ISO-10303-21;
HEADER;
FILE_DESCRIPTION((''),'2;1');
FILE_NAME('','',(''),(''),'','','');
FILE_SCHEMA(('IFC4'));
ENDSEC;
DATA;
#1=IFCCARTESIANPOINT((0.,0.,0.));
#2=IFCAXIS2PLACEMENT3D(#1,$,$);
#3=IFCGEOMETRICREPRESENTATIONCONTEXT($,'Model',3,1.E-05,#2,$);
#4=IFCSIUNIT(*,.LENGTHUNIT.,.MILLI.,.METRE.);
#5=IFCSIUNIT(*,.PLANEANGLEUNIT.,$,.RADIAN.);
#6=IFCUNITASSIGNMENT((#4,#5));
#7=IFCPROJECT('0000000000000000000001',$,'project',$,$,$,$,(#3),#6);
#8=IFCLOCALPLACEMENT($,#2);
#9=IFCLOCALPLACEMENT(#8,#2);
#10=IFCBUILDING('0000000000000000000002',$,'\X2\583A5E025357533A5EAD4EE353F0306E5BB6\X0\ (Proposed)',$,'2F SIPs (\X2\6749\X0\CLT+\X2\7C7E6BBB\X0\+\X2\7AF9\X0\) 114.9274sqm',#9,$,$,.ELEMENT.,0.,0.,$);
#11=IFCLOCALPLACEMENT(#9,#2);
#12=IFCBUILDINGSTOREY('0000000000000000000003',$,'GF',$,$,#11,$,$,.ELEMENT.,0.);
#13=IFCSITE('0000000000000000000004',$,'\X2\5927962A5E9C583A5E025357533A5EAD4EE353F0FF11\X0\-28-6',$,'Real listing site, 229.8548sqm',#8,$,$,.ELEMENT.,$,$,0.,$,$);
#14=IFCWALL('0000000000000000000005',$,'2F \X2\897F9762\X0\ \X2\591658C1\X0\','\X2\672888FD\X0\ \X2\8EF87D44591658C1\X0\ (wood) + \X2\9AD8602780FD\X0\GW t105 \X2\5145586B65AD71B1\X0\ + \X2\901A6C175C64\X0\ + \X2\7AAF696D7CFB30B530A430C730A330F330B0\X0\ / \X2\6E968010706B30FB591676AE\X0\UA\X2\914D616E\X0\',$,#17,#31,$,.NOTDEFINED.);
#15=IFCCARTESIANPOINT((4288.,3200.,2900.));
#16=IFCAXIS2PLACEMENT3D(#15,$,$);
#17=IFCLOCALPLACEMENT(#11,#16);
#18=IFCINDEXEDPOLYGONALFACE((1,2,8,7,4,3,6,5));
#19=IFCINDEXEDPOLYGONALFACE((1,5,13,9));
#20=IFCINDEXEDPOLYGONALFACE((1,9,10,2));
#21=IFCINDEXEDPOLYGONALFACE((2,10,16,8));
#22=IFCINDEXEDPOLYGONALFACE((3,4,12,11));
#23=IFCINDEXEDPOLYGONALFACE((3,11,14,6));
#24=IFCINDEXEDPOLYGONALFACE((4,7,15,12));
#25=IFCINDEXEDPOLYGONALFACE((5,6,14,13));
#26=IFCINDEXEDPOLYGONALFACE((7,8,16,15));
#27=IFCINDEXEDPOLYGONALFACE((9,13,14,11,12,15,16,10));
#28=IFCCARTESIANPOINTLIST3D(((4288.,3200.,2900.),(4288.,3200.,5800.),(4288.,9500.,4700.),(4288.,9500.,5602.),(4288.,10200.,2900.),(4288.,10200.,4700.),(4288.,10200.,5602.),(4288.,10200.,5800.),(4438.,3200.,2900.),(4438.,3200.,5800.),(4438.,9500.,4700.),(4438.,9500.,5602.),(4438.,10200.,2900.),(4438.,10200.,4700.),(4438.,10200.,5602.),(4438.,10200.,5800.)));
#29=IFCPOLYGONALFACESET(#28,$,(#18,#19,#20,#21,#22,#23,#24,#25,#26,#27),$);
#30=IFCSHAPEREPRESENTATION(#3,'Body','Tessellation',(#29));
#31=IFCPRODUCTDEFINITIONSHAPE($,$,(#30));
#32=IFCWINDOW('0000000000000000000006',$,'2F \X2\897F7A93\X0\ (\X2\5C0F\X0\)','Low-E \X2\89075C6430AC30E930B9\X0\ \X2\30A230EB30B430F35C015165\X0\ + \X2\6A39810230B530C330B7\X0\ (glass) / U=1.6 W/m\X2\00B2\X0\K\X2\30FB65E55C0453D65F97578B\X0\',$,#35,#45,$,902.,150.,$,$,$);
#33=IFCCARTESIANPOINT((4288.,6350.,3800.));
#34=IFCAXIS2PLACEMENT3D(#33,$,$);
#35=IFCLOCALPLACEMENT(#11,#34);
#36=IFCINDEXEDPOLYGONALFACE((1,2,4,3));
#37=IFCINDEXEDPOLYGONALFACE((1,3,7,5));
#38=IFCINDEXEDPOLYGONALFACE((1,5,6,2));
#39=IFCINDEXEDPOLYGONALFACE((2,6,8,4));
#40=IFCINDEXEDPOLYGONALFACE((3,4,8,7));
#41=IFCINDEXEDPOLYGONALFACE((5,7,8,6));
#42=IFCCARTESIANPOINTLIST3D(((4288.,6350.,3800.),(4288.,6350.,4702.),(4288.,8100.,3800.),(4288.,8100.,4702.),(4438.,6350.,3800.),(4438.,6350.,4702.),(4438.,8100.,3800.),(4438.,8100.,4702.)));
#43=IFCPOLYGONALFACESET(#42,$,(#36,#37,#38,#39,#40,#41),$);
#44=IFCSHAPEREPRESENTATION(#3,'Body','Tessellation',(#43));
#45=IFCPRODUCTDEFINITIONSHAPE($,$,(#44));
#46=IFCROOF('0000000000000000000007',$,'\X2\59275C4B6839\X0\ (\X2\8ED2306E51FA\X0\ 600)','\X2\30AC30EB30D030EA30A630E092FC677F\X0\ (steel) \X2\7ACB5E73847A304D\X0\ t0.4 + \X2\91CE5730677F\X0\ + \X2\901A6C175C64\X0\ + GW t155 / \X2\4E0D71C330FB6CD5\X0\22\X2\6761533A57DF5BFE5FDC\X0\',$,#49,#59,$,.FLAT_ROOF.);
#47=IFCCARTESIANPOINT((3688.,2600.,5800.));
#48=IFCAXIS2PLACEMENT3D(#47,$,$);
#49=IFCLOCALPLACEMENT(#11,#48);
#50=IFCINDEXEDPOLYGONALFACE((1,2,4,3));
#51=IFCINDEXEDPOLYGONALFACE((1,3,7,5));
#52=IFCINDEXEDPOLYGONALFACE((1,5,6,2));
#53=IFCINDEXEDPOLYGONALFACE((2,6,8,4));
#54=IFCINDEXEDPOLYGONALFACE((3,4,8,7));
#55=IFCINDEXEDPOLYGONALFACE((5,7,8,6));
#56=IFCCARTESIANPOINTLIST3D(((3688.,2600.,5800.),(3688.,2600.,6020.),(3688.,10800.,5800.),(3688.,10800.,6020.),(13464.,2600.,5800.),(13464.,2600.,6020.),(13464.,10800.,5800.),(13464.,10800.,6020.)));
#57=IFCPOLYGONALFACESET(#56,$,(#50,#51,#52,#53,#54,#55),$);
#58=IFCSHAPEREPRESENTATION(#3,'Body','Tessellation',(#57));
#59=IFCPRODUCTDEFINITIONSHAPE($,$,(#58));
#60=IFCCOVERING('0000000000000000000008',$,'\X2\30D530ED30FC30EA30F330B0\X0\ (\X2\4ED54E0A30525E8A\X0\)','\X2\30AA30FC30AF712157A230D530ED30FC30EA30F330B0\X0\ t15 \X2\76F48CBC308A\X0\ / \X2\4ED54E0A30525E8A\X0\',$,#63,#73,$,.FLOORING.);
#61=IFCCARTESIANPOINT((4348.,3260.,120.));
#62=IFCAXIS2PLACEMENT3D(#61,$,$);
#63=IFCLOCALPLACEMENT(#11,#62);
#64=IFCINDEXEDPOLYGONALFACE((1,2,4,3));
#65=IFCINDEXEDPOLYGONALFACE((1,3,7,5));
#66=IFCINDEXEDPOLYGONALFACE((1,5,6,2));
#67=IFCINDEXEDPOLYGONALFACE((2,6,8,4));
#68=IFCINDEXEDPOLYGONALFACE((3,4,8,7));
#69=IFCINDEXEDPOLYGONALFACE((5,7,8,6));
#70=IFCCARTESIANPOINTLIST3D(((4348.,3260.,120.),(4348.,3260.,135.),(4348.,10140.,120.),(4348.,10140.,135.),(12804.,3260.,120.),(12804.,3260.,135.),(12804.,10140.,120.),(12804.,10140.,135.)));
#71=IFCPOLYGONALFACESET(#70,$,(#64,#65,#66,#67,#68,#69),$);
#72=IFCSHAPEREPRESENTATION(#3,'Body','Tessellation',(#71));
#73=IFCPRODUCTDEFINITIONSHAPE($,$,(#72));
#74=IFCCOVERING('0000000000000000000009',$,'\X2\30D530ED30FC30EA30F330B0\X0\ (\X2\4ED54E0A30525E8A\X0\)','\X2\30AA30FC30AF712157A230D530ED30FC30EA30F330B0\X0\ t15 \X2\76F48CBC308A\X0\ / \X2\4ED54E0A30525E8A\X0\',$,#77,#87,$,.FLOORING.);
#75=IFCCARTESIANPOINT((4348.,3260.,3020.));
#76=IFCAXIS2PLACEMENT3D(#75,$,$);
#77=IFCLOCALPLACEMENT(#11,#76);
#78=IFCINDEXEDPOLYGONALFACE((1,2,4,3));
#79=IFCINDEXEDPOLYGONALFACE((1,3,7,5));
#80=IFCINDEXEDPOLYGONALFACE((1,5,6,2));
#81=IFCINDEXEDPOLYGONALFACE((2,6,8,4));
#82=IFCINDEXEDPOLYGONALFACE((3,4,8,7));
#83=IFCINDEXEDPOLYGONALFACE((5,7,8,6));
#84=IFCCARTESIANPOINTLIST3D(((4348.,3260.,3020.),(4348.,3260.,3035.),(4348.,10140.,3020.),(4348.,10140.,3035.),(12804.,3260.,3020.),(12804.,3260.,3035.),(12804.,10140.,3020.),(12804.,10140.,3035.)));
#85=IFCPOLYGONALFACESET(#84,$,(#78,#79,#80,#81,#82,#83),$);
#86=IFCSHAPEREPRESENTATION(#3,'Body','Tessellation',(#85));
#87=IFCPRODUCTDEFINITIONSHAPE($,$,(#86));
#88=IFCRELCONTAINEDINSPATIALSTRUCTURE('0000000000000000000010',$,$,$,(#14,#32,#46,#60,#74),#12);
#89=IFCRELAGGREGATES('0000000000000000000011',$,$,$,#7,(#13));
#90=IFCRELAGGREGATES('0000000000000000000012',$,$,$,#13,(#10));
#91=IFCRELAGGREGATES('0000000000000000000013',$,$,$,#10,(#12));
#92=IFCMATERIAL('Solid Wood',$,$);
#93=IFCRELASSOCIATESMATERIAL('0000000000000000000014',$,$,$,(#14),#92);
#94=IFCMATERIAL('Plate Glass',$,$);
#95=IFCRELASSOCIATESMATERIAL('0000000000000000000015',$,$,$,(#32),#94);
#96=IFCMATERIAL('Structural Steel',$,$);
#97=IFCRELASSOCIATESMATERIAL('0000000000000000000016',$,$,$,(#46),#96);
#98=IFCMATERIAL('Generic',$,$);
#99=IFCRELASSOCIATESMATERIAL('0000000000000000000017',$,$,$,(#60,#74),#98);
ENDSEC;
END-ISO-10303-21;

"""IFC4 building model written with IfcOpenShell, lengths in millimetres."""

from ifc_helpers import new_model, si_unit, frame, frame_2d, origin, place, context, project, spatial, rectangle, extrude, material, element, fill, save


model = new_model("IFC4")

# Units and contexts
model_context = context("Model", 3, precision=1e-05, world=origin())
ifc_project = project(units=[si_unit("LENGTHUNIT", "METRE", prefix="MILLI"), si_unit("PLANEANGLEUNIT", "RADIAN")], contexts=[model_context])

# Site, building, storey
site_placement = place(None, origin())
site = spatial("IfcSite", under=ifc_project, at=site_placement, Name="大阪府堺市南区庭代台１-28-6", ObjectType="Real listing site, 229.8548sqm", CompositionType="ELEMENT", RefElevation=0.0)
building_placement = place(site_placement, origin())
building = spatial("IfcBuilding", under=site, at=building_placement, Name="堺市南区庭代台の家 (Proposed)", ObjectType="2F SIPs (杉CLT+籾殻+竹) 114.9274sqm", CompositionType="ELEMENT", ElevationOfRefHeight=0.0, ElevationOfTerrain=0.0)
storey_placement = place(building_placement, origin())
storey = spatial("IfcBuildingStorey", under=building, at=storey_placement, Name="GF", CompositionType="ELEMENT", Elevation=0.0)

# Shared definitions
ifc_material_1 = material(Name="Solid Wood")

# Shared definitions
ifc_material_2 = material(Name="Plate Glass")

# Wall, opening, window
wall_1_placement = place(storey_placement, frame((4288.0, 3200.0, 2900.0)))
wall_1 = element("IfcWall", 1, at=wall_1_placement, inside=storey, material=ifc_material_1, Name="2F 西面 外壁", Description="木製 軸組外壁 (wood) + 高性能GW t105 充填断熱 + 通気層 + 窯業系サイディング / 準耐火・外皮UA配慮", PredefinedType="NOTDEFINED", context=model_context, shape_type="SweptSolid", body=[
    extrude(rectangle(XDim=150.0, YDim=7000.0, at=frame_2d((75.0, 3500.0))), frame((4288.0, 3200.0, 2900.0)), (0.0, 0.0, 1.0), 2900.0),
])
opening_1_placement = place(storey_placement, frame((4288.0, 6350.0, 3800.0)))
opening_1 = element("IfcOpeningElement", 2, at=opening_1_placement, cuts=wall_1, PredefinedType="NOTDEFINED", context=model_context, shape_type="SweptSolid", body=[
    extrude(rectangle(XDim=150.0, YDim=1750.0, at=frame_2d((75.0, 875.0))), frame((4288.0, 6350.0, 3800.0)), (0.0, 0.0, 1.0), 902.0),
])
window_1_placement = place(storey_placement, frame((4288.0, 6350.0, 3800.0)))
window_1 = element("IfcWindow", 3, at=window_1_placement, inside=storey, material=ifc_material_2, Name="2F 西窓 (小)", Description="Low-E 複層ガラス アルゴン封入 + 樹脂サッシ (glass) / U=1.6 W/m²K・日射取得型", OverallHeight=902.0, OverallWidth=150.0, context=model_context, shape_type="SweptSolid", body=[
    extrude(rectangle(XDim=150.0, YDim=1750.0, at=frame_2d((75.0, 875.0))), frame((4288.0, 6350.0, 3800.0)), (0.0, 0.0, 1.0), 902.0),
])
fill(opening_1, window_1)

# Roof
ifc_material_3 = material(Name="Structural Steel")
roof_placement = place(storey_placement, frame((3688.0, 2600.0, 5800.0)))
element("IfcRoof", 4, at=roof_placement, inside=storey, material=ifc_material_3, Name="大屋根 (軒の出 600)", Description="ガルバリウム鋼板 (steel) 立平葺き t0.4 + 野地板 + 通気層 + GW t155 / 不燃・法22条区域対応", PredefinedType="FLAT_ROOF", context=model_context, shape_type="SweptSolid", body=[
    extrude(rectangle(XDim=9776.0, YDim=8200.0, at=frame_2d((4888.0, 4100.0))), frame((3688.0, 2600.0, 5800.0)), (0.0, 0.0, 1.0), 220.0),
])

# Coverings
ifc_material_4 = material(Name="Generic")
covering_1_placement = place(storey_placement, frame((4348.0, 3260.0, 120.0)))
element("IfcCovering", 5, at=covering_1_placement, inside=storey, material=ifc_material_4, Name="フローリング (仕上げ床)", Description="オーク無垢フローリング t15 直貼り / 仕上げ床", PredefinedType="FLOORING", context=model_context, shape_type="SweptSolid", body=[
    extrude(rectangle(XDim=8456.0, YDim=6880.0, at=frame_2d((4228.0, 3440.0))), frame((4348.0, 3260.0, 120.0)), (0.0, 0.0, 1.0), 15.0),
])
covering_2_placement = place(storey_placement, frame((4348.0, 3260.0, 3020.0)))
element("IfcCovering", 6, at=covering_2_placement, inside=storey, material=ifc_material_4, Name="フローリング (仕上げ床)", Description="オーク無垢フローリング t15 直貼り / 仕上げ床", PredefinedType="FLOORING", context=model_context, shape_type="SweptSolid", body=[
    extrude(rectangle(XDim=8456.0, YDim=6880.0, at=frame_2d((4228.0, 3440.0))), frame((4348.0, 3260.0, 3020.0)), (0.0, 0.0, 1.0), 15.0),
])

save(model, "model.ifc")
